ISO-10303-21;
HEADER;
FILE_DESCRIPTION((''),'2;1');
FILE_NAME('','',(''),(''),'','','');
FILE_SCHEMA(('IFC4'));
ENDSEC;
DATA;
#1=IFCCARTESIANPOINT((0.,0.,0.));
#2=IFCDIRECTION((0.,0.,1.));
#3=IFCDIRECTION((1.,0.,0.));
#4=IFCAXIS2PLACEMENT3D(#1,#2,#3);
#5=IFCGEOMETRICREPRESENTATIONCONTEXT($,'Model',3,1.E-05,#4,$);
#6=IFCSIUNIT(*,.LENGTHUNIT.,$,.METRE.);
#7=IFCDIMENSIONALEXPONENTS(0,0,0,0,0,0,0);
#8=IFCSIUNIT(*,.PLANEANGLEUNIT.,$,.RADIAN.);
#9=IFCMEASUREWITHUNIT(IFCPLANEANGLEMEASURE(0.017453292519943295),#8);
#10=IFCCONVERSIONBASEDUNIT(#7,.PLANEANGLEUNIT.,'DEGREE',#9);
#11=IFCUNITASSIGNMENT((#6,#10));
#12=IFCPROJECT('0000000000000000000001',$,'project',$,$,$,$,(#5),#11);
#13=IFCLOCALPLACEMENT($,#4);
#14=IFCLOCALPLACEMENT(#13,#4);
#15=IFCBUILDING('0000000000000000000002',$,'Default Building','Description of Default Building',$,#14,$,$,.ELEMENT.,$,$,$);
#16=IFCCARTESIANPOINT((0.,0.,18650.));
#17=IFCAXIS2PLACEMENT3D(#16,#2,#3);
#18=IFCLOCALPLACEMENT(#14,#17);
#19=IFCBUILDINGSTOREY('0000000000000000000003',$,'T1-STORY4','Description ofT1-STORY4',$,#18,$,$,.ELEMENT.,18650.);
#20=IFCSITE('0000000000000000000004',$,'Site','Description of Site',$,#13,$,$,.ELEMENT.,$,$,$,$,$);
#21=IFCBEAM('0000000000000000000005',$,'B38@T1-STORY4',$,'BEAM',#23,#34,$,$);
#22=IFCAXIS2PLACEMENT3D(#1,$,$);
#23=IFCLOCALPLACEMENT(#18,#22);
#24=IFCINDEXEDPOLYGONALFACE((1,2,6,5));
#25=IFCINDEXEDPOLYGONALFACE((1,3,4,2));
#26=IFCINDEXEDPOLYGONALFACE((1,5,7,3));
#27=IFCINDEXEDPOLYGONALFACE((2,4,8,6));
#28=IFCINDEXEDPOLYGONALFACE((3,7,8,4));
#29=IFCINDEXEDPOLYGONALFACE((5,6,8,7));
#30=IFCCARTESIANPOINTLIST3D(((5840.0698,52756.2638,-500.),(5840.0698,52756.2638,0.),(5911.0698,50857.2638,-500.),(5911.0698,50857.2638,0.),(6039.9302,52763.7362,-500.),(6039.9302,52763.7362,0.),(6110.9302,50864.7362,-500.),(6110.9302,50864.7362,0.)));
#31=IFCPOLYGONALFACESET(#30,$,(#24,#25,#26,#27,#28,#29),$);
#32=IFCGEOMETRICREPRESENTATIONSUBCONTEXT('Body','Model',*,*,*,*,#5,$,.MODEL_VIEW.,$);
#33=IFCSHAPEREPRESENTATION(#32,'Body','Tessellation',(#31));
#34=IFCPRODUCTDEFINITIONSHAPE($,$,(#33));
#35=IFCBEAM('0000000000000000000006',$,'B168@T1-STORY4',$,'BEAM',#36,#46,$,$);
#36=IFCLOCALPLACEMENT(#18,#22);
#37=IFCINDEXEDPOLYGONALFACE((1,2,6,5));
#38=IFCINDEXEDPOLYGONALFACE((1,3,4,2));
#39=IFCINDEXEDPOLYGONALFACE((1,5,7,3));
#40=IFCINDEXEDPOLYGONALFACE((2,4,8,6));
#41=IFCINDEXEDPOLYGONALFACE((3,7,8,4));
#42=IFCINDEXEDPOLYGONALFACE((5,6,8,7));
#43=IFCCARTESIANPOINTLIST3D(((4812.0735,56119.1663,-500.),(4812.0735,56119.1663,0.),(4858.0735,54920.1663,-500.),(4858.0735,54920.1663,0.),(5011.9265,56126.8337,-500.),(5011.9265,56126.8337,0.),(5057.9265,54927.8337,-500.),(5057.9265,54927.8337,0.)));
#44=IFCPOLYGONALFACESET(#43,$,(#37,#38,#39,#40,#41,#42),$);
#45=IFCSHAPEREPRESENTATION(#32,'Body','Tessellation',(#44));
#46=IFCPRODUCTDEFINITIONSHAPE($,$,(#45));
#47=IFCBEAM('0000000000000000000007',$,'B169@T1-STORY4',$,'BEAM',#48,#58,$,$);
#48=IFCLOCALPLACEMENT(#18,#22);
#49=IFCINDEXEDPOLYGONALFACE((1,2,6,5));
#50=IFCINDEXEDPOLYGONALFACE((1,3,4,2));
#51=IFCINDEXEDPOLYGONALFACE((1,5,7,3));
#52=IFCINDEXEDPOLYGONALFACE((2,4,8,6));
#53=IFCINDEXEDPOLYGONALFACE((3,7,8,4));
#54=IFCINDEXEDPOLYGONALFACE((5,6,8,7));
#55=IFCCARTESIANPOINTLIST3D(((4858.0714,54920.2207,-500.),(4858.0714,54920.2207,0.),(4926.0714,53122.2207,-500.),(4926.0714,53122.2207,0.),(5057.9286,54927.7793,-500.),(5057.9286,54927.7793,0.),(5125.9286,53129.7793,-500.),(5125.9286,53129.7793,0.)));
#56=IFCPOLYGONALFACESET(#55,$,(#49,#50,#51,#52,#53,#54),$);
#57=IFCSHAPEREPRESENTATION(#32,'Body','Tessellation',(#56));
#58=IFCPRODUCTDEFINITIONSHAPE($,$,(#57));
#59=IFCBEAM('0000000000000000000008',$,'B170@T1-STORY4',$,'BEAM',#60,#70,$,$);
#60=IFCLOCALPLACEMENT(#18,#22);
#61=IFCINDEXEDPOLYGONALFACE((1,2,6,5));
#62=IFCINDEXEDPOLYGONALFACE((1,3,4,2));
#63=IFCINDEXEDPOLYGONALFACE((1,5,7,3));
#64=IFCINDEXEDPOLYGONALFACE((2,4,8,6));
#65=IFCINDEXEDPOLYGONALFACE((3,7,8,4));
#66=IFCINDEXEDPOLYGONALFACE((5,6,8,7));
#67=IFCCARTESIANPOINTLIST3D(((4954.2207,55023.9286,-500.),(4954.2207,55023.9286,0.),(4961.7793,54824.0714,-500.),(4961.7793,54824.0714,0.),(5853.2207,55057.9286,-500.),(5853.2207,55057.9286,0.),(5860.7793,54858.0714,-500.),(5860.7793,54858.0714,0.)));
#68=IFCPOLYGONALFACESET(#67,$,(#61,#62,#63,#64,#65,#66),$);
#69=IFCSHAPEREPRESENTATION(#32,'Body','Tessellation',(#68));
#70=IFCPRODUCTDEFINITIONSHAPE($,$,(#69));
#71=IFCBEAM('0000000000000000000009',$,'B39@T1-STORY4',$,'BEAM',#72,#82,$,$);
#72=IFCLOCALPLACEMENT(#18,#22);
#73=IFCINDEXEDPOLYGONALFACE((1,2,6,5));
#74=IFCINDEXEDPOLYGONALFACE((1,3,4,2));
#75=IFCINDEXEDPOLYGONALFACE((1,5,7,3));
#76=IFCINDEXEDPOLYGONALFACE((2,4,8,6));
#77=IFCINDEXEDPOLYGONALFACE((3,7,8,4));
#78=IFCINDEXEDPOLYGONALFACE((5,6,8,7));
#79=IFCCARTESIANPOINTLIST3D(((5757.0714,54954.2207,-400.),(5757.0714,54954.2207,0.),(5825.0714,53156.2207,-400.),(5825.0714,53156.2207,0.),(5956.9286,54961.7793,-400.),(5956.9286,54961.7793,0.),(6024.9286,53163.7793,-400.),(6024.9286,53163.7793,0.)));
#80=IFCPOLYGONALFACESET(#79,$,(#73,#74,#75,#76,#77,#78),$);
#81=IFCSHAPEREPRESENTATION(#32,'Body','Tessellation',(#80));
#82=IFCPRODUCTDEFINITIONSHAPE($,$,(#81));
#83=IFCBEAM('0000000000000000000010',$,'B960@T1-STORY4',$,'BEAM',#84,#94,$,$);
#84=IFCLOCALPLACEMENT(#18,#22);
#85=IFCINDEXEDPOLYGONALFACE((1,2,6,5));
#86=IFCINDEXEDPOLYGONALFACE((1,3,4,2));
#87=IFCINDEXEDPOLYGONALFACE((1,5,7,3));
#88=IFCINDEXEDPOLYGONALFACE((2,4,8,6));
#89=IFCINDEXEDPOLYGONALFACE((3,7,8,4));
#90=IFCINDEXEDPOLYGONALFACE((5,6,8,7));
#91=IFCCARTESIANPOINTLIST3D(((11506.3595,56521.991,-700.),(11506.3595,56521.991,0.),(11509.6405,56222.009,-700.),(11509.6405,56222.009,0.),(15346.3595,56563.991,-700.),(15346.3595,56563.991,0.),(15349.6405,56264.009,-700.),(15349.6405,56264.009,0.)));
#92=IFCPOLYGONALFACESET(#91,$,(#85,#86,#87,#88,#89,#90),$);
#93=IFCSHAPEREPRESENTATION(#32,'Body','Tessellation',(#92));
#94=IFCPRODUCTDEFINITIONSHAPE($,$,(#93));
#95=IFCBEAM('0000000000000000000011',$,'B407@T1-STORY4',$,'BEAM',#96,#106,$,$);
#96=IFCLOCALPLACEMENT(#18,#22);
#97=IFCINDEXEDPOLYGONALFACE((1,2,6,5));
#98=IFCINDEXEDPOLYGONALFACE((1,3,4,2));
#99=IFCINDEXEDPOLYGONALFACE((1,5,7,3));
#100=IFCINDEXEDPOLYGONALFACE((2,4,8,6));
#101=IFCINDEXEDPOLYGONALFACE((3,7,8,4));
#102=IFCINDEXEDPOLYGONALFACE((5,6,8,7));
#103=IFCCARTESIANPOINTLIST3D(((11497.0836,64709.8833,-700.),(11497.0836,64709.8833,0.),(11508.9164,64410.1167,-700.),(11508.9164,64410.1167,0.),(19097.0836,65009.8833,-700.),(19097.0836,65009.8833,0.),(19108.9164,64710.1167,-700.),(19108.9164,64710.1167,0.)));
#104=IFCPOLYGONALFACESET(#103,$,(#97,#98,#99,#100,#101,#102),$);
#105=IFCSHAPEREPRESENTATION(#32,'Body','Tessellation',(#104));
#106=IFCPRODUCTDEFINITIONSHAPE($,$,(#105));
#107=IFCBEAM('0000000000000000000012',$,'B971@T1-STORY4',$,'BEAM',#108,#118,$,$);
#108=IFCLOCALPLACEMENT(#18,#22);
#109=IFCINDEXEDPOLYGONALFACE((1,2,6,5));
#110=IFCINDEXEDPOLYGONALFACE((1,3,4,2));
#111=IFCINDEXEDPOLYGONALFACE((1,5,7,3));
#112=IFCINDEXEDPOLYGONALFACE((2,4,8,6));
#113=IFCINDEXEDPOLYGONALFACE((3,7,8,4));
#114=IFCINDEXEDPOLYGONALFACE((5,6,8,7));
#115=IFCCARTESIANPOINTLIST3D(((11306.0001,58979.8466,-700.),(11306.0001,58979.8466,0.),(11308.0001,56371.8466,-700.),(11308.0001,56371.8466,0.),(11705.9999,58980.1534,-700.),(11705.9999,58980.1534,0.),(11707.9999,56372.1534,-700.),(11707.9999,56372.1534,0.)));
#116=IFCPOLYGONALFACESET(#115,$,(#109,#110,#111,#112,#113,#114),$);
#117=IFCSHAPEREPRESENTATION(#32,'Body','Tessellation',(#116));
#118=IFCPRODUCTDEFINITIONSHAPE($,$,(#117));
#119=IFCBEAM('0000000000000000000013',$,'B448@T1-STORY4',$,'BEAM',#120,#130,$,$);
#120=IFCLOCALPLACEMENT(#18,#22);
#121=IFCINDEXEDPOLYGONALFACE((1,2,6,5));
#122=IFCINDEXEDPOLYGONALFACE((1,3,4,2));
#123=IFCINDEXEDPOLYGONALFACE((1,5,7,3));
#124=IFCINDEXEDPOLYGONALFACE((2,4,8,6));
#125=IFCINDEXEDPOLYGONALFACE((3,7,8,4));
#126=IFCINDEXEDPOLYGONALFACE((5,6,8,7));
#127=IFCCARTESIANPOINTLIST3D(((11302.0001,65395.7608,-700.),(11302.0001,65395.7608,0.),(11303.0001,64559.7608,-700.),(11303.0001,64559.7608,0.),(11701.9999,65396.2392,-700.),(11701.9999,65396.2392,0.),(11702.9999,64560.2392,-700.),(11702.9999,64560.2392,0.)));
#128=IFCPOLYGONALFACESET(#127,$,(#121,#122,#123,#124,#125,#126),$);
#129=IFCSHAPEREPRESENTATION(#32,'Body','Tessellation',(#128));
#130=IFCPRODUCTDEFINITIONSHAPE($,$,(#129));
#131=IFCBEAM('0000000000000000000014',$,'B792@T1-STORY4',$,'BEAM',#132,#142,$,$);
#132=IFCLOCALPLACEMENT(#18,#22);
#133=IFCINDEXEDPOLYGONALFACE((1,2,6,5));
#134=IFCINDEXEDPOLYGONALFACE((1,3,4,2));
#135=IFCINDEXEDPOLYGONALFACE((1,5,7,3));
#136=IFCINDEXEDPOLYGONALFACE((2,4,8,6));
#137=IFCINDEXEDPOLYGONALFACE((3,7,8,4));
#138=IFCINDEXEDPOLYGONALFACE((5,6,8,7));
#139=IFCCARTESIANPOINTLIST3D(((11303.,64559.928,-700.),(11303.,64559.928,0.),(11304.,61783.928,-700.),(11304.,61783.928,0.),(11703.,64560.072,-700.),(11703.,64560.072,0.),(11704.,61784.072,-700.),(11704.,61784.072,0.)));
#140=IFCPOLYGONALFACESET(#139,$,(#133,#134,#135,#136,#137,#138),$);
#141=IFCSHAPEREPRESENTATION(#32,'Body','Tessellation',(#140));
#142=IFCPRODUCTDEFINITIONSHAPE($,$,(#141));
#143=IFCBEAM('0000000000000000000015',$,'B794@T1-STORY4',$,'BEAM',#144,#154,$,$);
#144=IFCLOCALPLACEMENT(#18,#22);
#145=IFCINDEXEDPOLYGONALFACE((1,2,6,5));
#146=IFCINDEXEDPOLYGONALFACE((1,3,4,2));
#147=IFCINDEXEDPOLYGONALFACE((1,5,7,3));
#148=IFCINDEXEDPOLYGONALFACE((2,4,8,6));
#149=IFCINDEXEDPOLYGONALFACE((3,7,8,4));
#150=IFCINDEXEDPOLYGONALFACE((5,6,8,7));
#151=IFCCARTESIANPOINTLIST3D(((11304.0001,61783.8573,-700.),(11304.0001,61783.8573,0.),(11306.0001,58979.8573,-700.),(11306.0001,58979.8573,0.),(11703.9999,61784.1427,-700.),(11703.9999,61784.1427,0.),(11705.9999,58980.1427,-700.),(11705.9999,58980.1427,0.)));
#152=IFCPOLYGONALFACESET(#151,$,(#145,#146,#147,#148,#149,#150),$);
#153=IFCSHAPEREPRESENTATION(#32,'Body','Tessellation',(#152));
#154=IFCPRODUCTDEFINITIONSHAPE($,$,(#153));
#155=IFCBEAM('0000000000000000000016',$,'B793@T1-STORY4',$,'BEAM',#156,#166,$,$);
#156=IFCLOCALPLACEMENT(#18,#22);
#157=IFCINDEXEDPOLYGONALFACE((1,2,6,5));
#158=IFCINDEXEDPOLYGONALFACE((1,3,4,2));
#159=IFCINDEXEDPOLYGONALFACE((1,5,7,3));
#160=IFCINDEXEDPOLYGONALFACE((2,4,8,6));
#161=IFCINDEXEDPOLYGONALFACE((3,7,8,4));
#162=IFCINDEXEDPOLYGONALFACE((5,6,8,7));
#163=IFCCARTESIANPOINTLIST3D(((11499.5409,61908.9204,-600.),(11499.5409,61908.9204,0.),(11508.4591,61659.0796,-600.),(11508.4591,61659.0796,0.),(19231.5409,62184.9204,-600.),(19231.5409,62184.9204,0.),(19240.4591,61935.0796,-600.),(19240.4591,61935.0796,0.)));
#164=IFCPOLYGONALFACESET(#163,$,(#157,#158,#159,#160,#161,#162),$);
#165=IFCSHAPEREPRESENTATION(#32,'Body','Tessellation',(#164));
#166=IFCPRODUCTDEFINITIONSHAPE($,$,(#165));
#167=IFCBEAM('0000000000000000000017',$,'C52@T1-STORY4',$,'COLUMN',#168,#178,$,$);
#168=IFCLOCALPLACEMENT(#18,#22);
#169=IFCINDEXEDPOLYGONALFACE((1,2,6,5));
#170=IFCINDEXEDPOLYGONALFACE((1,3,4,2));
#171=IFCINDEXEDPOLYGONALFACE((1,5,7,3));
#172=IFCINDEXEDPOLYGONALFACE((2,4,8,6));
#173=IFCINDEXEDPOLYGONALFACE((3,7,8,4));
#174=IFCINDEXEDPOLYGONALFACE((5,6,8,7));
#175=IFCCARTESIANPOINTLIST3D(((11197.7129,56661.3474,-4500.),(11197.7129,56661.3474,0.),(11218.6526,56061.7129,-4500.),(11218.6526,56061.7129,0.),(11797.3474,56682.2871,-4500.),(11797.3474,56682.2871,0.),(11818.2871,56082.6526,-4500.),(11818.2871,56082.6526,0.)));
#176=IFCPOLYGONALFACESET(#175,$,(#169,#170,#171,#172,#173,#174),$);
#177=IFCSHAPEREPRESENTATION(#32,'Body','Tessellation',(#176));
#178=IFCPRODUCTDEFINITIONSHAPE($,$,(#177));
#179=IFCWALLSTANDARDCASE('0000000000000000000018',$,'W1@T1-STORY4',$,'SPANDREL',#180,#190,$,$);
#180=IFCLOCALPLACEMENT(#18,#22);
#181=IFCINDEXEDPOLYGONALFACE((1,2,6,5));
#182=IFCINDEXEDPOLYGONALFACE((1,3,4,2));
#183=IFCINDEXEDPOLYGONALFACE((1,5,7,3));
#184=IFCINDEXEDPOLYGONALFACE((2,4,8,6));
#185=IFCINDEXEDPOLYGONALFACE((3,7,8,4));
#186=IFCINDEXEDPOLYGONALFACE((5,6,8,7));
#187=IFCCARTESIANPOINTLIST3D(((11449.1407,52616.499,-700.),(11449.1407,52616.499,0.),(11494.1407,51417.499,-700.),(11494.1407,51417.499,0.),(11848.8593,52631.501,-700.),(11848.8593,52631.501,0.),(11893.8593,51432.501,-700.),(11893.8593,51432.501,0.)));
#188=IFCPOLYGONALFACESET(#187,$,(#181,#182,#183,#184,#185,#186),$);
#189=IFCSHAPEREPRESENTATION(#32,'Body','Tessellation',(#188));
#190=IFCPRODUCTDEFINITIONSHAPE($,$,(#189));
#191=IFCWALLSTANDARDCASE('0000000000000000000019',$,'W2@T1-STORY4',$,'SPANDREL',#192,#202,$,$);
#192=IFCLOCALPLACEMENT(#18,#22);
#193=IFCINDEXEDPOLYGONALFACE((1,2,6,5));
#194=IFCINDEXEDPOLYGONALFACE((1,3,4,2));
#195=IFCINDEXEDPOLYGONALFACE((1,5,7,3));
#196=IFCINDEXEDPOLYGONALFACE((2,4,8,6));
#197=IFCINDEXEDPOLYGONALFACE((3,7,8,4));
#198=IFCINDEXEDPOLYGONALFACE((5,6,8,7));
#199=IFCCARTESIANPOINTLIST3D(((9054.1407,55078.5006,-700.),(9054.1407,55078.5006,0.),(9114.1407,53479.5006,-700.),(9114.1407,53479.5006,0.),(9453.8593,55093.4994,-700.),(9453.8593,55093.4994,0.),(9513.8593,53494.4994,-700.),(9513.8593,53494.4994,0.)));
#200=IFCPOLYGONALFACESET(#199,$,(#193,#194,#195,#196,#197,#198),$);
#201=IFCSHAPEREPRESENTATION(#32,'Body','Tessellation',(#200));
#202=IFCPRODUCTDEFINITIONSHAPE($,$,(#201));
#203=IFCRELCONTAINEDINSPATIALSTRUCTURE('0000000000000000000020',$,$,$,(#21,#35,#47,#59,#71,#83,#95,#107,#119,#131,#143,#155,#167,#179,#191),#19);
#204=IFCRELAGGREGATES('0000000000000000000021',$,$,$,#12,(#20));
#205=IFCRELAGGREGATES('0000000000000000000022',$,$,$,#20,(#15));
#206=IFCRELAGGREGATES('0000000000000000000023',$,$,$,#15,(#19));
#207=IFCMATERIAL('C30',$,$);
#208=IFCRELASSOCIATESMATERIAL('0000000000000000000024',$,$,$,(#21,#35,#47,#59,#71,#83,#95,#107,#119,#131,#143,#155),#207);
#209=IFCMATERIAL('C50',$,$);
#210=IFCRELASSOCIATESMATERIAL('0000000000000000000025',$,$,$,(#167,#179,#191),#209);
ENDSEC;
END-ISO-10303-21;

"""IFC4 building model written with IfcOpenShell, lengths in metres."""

from ifc_helpers import new_model, entity, si_unit, converted_unit, frame, origin_with_axes, place, context, subcontext, project, spatial, indexed_curve, rectangle, outline, extrude, material, element, save


model = new_model("IFC4")

# Units and contexts
model_context = context("Model", 3, precision=1e-05, world=origin_with_axes())
body_context = subcontext(model_context, "Body", "Model", "MODEL_VIEW")
ifc_project = project(units=[si_unit("LENGTHUNIT", "METRE"), converted_unit("PLANEANGLEUNIT", "DEGREE", entity("IfcPlaneAngleMeasure", 0.017453292519943295), si_unit("PLANEANGLEUNIT", "RADIAN"), dimensions=[0, 0, 0, 0, 0, 0, 0])], contexts=[model_context])

# Site, building, storey
site_placement = place(None, origin_with_axes())
site = spatial("IfcSite", under=ifc_project, at=site_placement, Name="Site", Description="Description of Site", CompositionType="ELEMENT")
building_placement = place(site_placement, origin_with_axes())
building = spatial("IfcBuilding", under=site, at=building_placement, Name="Default Building", Description="Description of Default Building", CompositionType="ELEMENT")
storey_placement = place(building_placement, frame((0.0, 0.0, 18650.0), z_axis=(0.0, 0.0, 1.0), x_axis=(1.0, 0.0, 0.0)))
storey = spatial("IfcBuildingStorey", under=building, at=storey_placement, Name="T1-STORY4", Description="Description ofT1-STORY4", CompositionType="ELEMENT", Elevation=18650.0)

# Beams
ifc_material_1 = material(Name="C30")
beam_1_placement = place(storey_placement, frame((5940.0, 52760.0, -250.0), z_axis=(0.037362, -0.999302, 0.0), x_axis=(0.999302, 0.037362, 0.0)))
element("IfcBeam", 1, at=beam_1_placement, inside=storey, material=ifc_material_1, Name="B38@T1-STORY4", ObjectType="BEAM", context=body_context, shape_type="SweptSolid", body=[
    extrude(rectangle(XDim=200.0, YDim=500.0), origin_with_axes(), (0.0, 0.0, 1.0), 1900.3268),
])
beam_2_placement = place(storey_placement, frame((4912.0, 56123.0, -250.0), z_axis=(0.038337, -0.999265, 0.0), x_axis=(0.999265, 0.038337, 0.0)))
element("IfcBeam", 2, at=beam_2_placement, inside=storey, material=ifc_material_1, Name="B168@T1-STORY4", ObjectType="BEAM", context=body_context, shape_type="SweptSolid", body=[
    extrude(rectangle(XDim=200.0, YDim=500.0), origin_with_axes(), (0.0, 0.0, 1.0), 1199.8821),
])
beam_3_placement = place(storey_placement, frame((4958.0, 54924.0, -250.0), z_axis=(0.037793, -0.999286, 0.0), x_axis=(0.999286, 0.037793, 0.0)))
element("IfcBeam", 3, at=beam_3_placement, inside=storey, material=ifc_material_1, Name="B169@T1-STORY4", ObjectType="BEAM", context=body_context, shape_type="SweptSolid", body=[
    extrude(rectangle(XDim=200.0, YDim=500.0), origin_with_axes(), (0.0, 0.0, 1.0), 1799.2854),
])
beam_4_placement = place(storey_placement, frame((4958.0, 54924.0, -250.0), z_axis=(0.999286, 0.037793, 0.0), x_axis=(-0.037793, 0.999286, 0.0)))
element("IfcBeam", 4, at=beam_4_placement, inside=storey, material=ifc_material_1, Name="B170@T1-STORY4", ObjectType="BEAM", context=body_context, shape_type="SweptSolid", body=[
    extrude(rectangle(XDim=200.0, YDim=500.0), origin_with_axes(), (0.0, 0.0, 1.0), 899.6427),
])
beam_5_placement = place(storey_placement, frame((5857.0, 54958.0, -200.0), z_axis=(0.037793, -0.999286, 0.0), x_axis=(0.999286, 0.037793, 0.0)))
element("IfcBeam", 5, at=beam_5_placement, inside=storey, material=ifc_material_1, Name="B39@T1-STORY4", ObjectType="BEAM", context=body_context, shape_type="SweptSolid", body=[
    extrude(rectangle(XDim=200.0, YDim=400.0), origin_with_axes(), (0.0, 0.0, 1.0), 1799.2854),
])
beam_6_placement = place(storey_placement, frame((11508.0, 56372.0, -350.0), z_axis=(0.99994, 0.010937, 0.0), x_axis=(-0.010937, 0.99994, 0.0)))
element("IfcBeam", 6, at=beam_6_placement, inside=storey, material=ifc_material_1, Name="B960@T1-STORY4", ObjectType="BEAM", context=body_context, shape_type="SweptSolid", body=[
    extrude(rectangle(XDim=300.0, YDim=700.0), origin_with_axes(), (0.0, 0.0, 1.0), 3840.2297),
])
beam_7_placement = place(storey_placement, frame((11503.0, 64560.0, -350.0), z_axis=(0.999222, 0.039443, 0.0), x_axis=(-0.039443, 0.999222, 0.0)))
element("IfcBeam", 7, at=beam_7_placement, inside=storey, material=ifc_material_1, Name="B407@T1-STORY4", ObjectType="BEAM", context=body_context, shape_type="SweptSolid", body=[
    extrude(rectangle(XDim=300.0, YDim=700.0), origin_with_axes(), (0.0, 0.0, 1.0), 7605.9187),
])
beam_8_placement = place(storey_placement, frame((11508.0, 56372.0, -350.0), z_axis=(-0.000767, 1.0, 0.0), x_axis=(-1.0, -0.000767, 0.0)))
element("IfcBeam", 8, at=beam_8_placement, inside=storey, material=ifc_material_1, Name="B971@T1-STORY4", ObjectType="BEAM", context=body_context, shape_type="SweptSolid", body=[
    extrude(rectangle(XDim=400.0, YDim=700.0), origin_with_axes(), (0.0, 0.0, 1.0), 2608.0008),
])
beam_9_placement = place(storey_placement, frame((11503.0, 64560.0, -350.0), z_axis=(-0.001196, 0.999999, 0.0), x_axis=(-0.999999, -0.001196, 0.0)))
element("IfcBeam", 9, at=beam_9_placement, inside=storey, material=ifc_material_1, Name="B448@T1-STORY4", ObjectType="BEAM", context=body_context, shape_type="SweptSolid", body=[
    extrude(rectangle(XDim=400.0, YDim=700.0), origin_with_axes(), (0.0, 0.0, 1.0), 836.0006),
])
beam_10_placement = place(storey_placement, frame((11504.0, 61784.0, -350.0), z_axis=(-0.00036, 1.0, 0.0), x_axis=(-1.0, -0.00036, 0.0)))
element("IfcBeam", 10, at=beam_10_placement, inside=storey, material=ifc_material_1, Name="B792@T1-STORY4", ObjectType="BEAM", context=body_context, shape_type="SweptSolid", body=[
    extrude(rectangle(XDim=400.0, YDim=700.0), origin_with_axes(), (0.0, 0.0, 1.0), 2776.0002),
])
beam_11_placement = place(storey_placement, frame((11506.0, 58980.0, -350.0), z_axis=(-0.000713, 1.0, 0.0), x_axis=(-1.0, -0.000713, 0.0)))
element("IfcBeam", 11, at=beam_11_placement, inside=storey, material=ifc_material_1, Name="B794@T1-STORY4", ObjectType="BEAM", context=body_context, shape_type="SweptSolid", body=[
    extrude(rectangle(XDim=400.0, YDim=700.0), origin_with_axes(), (0.0, 0.0, 1.0), 2804.0007),
])
beam_12_placement = place(storey_placement, frame((11504.0, 61784.0, -300.0), z_axis=(0.999364, 0.035673, 0.0), x_axis=(-0.035673, 0.999364, 0.0)))
element("IfcBeam", 12, at=beam_12_placement, inside=storey, material=ifc_material_1, Name="B793@T1-STORY4", ObjectType="BEAM", context=body_context, shape_type="SweptSolid", body=[
    extrude(rectangle(XDim=250.0, YDim=600.0), origin_with_axes(), (0.0, 0.0, 1.0), 7736.9245),
])
ifc_material_2 = material(Name="C50")
beam_13_placement = place(storey_placement, frame((11508.0, 56372.0, -4500.0), z_axis=(0.0, 0.0, 1.0), x_axis=(-0.999391, -0.034899, 0.0)))
element("IfcBeam", 13, at=beam_13_placement, inside=storey, material=ifc_material_2, Name="C52@T1-STORY4", ObjectType="COLUMN", context=body_context, shape_type="SweptSolid", body=[
    extrude(rectangle(XDim=600.0, YDim=600.0), origin_with_axes(), (0.0, 0.0, 1.0), 4500.0),
])

# Walls
wall_1_placement = place(storey_placement, frame((11649.0, 52624.0, -700.0), z_axis=(0.0, 0.0, 1.0), x_axis=(0.037505, -0.999296, 0.0)))
element("IfcWallStandardCase", 14, at=wall_1_placement, inside=storey, material=ifc_material_2, Name="W1@T1-STORY4", ObjectType="SPANDREL", context=body_context, shape_type="SweptSolid", body=[
    extrude(outline(indexed_curve([(0.0, -200.0), (0.0, 200.0), (1199.8442, 200.0), (1199.8442, -200.0), (0.0, -200.0)], self_intersect=False)), origin_with_axes(), (0.0, 0.0, 1.0), 700.0),
])
wall_2_placement = place(storey_placement, frame((9254.0, 55086.0, -700.0), z_axis=(0.0, 0.0, 1.0), x_axis=(0.037497, -0.999297, 0.0)))
element("IfcWallStandardCase", 15, at=wall_2_placement, inside=storey, material=ifc_material_2, Name="W2@T1-STORY4", ObjectType="SPANDREL", context=body_context, shape_type="SweptSolid", body=[
    extrude(outline(indexed_curve([(0.0, -200.0), (0.0, 200.0), (1600.1253, 200.0), (1600.1253, -200.0), (0.0, -200.0)], self_intersect=False)), origin_with_axes(), (0.0, 0.0, 1.0), 700.0),
])

save(model, "model.ifc")
